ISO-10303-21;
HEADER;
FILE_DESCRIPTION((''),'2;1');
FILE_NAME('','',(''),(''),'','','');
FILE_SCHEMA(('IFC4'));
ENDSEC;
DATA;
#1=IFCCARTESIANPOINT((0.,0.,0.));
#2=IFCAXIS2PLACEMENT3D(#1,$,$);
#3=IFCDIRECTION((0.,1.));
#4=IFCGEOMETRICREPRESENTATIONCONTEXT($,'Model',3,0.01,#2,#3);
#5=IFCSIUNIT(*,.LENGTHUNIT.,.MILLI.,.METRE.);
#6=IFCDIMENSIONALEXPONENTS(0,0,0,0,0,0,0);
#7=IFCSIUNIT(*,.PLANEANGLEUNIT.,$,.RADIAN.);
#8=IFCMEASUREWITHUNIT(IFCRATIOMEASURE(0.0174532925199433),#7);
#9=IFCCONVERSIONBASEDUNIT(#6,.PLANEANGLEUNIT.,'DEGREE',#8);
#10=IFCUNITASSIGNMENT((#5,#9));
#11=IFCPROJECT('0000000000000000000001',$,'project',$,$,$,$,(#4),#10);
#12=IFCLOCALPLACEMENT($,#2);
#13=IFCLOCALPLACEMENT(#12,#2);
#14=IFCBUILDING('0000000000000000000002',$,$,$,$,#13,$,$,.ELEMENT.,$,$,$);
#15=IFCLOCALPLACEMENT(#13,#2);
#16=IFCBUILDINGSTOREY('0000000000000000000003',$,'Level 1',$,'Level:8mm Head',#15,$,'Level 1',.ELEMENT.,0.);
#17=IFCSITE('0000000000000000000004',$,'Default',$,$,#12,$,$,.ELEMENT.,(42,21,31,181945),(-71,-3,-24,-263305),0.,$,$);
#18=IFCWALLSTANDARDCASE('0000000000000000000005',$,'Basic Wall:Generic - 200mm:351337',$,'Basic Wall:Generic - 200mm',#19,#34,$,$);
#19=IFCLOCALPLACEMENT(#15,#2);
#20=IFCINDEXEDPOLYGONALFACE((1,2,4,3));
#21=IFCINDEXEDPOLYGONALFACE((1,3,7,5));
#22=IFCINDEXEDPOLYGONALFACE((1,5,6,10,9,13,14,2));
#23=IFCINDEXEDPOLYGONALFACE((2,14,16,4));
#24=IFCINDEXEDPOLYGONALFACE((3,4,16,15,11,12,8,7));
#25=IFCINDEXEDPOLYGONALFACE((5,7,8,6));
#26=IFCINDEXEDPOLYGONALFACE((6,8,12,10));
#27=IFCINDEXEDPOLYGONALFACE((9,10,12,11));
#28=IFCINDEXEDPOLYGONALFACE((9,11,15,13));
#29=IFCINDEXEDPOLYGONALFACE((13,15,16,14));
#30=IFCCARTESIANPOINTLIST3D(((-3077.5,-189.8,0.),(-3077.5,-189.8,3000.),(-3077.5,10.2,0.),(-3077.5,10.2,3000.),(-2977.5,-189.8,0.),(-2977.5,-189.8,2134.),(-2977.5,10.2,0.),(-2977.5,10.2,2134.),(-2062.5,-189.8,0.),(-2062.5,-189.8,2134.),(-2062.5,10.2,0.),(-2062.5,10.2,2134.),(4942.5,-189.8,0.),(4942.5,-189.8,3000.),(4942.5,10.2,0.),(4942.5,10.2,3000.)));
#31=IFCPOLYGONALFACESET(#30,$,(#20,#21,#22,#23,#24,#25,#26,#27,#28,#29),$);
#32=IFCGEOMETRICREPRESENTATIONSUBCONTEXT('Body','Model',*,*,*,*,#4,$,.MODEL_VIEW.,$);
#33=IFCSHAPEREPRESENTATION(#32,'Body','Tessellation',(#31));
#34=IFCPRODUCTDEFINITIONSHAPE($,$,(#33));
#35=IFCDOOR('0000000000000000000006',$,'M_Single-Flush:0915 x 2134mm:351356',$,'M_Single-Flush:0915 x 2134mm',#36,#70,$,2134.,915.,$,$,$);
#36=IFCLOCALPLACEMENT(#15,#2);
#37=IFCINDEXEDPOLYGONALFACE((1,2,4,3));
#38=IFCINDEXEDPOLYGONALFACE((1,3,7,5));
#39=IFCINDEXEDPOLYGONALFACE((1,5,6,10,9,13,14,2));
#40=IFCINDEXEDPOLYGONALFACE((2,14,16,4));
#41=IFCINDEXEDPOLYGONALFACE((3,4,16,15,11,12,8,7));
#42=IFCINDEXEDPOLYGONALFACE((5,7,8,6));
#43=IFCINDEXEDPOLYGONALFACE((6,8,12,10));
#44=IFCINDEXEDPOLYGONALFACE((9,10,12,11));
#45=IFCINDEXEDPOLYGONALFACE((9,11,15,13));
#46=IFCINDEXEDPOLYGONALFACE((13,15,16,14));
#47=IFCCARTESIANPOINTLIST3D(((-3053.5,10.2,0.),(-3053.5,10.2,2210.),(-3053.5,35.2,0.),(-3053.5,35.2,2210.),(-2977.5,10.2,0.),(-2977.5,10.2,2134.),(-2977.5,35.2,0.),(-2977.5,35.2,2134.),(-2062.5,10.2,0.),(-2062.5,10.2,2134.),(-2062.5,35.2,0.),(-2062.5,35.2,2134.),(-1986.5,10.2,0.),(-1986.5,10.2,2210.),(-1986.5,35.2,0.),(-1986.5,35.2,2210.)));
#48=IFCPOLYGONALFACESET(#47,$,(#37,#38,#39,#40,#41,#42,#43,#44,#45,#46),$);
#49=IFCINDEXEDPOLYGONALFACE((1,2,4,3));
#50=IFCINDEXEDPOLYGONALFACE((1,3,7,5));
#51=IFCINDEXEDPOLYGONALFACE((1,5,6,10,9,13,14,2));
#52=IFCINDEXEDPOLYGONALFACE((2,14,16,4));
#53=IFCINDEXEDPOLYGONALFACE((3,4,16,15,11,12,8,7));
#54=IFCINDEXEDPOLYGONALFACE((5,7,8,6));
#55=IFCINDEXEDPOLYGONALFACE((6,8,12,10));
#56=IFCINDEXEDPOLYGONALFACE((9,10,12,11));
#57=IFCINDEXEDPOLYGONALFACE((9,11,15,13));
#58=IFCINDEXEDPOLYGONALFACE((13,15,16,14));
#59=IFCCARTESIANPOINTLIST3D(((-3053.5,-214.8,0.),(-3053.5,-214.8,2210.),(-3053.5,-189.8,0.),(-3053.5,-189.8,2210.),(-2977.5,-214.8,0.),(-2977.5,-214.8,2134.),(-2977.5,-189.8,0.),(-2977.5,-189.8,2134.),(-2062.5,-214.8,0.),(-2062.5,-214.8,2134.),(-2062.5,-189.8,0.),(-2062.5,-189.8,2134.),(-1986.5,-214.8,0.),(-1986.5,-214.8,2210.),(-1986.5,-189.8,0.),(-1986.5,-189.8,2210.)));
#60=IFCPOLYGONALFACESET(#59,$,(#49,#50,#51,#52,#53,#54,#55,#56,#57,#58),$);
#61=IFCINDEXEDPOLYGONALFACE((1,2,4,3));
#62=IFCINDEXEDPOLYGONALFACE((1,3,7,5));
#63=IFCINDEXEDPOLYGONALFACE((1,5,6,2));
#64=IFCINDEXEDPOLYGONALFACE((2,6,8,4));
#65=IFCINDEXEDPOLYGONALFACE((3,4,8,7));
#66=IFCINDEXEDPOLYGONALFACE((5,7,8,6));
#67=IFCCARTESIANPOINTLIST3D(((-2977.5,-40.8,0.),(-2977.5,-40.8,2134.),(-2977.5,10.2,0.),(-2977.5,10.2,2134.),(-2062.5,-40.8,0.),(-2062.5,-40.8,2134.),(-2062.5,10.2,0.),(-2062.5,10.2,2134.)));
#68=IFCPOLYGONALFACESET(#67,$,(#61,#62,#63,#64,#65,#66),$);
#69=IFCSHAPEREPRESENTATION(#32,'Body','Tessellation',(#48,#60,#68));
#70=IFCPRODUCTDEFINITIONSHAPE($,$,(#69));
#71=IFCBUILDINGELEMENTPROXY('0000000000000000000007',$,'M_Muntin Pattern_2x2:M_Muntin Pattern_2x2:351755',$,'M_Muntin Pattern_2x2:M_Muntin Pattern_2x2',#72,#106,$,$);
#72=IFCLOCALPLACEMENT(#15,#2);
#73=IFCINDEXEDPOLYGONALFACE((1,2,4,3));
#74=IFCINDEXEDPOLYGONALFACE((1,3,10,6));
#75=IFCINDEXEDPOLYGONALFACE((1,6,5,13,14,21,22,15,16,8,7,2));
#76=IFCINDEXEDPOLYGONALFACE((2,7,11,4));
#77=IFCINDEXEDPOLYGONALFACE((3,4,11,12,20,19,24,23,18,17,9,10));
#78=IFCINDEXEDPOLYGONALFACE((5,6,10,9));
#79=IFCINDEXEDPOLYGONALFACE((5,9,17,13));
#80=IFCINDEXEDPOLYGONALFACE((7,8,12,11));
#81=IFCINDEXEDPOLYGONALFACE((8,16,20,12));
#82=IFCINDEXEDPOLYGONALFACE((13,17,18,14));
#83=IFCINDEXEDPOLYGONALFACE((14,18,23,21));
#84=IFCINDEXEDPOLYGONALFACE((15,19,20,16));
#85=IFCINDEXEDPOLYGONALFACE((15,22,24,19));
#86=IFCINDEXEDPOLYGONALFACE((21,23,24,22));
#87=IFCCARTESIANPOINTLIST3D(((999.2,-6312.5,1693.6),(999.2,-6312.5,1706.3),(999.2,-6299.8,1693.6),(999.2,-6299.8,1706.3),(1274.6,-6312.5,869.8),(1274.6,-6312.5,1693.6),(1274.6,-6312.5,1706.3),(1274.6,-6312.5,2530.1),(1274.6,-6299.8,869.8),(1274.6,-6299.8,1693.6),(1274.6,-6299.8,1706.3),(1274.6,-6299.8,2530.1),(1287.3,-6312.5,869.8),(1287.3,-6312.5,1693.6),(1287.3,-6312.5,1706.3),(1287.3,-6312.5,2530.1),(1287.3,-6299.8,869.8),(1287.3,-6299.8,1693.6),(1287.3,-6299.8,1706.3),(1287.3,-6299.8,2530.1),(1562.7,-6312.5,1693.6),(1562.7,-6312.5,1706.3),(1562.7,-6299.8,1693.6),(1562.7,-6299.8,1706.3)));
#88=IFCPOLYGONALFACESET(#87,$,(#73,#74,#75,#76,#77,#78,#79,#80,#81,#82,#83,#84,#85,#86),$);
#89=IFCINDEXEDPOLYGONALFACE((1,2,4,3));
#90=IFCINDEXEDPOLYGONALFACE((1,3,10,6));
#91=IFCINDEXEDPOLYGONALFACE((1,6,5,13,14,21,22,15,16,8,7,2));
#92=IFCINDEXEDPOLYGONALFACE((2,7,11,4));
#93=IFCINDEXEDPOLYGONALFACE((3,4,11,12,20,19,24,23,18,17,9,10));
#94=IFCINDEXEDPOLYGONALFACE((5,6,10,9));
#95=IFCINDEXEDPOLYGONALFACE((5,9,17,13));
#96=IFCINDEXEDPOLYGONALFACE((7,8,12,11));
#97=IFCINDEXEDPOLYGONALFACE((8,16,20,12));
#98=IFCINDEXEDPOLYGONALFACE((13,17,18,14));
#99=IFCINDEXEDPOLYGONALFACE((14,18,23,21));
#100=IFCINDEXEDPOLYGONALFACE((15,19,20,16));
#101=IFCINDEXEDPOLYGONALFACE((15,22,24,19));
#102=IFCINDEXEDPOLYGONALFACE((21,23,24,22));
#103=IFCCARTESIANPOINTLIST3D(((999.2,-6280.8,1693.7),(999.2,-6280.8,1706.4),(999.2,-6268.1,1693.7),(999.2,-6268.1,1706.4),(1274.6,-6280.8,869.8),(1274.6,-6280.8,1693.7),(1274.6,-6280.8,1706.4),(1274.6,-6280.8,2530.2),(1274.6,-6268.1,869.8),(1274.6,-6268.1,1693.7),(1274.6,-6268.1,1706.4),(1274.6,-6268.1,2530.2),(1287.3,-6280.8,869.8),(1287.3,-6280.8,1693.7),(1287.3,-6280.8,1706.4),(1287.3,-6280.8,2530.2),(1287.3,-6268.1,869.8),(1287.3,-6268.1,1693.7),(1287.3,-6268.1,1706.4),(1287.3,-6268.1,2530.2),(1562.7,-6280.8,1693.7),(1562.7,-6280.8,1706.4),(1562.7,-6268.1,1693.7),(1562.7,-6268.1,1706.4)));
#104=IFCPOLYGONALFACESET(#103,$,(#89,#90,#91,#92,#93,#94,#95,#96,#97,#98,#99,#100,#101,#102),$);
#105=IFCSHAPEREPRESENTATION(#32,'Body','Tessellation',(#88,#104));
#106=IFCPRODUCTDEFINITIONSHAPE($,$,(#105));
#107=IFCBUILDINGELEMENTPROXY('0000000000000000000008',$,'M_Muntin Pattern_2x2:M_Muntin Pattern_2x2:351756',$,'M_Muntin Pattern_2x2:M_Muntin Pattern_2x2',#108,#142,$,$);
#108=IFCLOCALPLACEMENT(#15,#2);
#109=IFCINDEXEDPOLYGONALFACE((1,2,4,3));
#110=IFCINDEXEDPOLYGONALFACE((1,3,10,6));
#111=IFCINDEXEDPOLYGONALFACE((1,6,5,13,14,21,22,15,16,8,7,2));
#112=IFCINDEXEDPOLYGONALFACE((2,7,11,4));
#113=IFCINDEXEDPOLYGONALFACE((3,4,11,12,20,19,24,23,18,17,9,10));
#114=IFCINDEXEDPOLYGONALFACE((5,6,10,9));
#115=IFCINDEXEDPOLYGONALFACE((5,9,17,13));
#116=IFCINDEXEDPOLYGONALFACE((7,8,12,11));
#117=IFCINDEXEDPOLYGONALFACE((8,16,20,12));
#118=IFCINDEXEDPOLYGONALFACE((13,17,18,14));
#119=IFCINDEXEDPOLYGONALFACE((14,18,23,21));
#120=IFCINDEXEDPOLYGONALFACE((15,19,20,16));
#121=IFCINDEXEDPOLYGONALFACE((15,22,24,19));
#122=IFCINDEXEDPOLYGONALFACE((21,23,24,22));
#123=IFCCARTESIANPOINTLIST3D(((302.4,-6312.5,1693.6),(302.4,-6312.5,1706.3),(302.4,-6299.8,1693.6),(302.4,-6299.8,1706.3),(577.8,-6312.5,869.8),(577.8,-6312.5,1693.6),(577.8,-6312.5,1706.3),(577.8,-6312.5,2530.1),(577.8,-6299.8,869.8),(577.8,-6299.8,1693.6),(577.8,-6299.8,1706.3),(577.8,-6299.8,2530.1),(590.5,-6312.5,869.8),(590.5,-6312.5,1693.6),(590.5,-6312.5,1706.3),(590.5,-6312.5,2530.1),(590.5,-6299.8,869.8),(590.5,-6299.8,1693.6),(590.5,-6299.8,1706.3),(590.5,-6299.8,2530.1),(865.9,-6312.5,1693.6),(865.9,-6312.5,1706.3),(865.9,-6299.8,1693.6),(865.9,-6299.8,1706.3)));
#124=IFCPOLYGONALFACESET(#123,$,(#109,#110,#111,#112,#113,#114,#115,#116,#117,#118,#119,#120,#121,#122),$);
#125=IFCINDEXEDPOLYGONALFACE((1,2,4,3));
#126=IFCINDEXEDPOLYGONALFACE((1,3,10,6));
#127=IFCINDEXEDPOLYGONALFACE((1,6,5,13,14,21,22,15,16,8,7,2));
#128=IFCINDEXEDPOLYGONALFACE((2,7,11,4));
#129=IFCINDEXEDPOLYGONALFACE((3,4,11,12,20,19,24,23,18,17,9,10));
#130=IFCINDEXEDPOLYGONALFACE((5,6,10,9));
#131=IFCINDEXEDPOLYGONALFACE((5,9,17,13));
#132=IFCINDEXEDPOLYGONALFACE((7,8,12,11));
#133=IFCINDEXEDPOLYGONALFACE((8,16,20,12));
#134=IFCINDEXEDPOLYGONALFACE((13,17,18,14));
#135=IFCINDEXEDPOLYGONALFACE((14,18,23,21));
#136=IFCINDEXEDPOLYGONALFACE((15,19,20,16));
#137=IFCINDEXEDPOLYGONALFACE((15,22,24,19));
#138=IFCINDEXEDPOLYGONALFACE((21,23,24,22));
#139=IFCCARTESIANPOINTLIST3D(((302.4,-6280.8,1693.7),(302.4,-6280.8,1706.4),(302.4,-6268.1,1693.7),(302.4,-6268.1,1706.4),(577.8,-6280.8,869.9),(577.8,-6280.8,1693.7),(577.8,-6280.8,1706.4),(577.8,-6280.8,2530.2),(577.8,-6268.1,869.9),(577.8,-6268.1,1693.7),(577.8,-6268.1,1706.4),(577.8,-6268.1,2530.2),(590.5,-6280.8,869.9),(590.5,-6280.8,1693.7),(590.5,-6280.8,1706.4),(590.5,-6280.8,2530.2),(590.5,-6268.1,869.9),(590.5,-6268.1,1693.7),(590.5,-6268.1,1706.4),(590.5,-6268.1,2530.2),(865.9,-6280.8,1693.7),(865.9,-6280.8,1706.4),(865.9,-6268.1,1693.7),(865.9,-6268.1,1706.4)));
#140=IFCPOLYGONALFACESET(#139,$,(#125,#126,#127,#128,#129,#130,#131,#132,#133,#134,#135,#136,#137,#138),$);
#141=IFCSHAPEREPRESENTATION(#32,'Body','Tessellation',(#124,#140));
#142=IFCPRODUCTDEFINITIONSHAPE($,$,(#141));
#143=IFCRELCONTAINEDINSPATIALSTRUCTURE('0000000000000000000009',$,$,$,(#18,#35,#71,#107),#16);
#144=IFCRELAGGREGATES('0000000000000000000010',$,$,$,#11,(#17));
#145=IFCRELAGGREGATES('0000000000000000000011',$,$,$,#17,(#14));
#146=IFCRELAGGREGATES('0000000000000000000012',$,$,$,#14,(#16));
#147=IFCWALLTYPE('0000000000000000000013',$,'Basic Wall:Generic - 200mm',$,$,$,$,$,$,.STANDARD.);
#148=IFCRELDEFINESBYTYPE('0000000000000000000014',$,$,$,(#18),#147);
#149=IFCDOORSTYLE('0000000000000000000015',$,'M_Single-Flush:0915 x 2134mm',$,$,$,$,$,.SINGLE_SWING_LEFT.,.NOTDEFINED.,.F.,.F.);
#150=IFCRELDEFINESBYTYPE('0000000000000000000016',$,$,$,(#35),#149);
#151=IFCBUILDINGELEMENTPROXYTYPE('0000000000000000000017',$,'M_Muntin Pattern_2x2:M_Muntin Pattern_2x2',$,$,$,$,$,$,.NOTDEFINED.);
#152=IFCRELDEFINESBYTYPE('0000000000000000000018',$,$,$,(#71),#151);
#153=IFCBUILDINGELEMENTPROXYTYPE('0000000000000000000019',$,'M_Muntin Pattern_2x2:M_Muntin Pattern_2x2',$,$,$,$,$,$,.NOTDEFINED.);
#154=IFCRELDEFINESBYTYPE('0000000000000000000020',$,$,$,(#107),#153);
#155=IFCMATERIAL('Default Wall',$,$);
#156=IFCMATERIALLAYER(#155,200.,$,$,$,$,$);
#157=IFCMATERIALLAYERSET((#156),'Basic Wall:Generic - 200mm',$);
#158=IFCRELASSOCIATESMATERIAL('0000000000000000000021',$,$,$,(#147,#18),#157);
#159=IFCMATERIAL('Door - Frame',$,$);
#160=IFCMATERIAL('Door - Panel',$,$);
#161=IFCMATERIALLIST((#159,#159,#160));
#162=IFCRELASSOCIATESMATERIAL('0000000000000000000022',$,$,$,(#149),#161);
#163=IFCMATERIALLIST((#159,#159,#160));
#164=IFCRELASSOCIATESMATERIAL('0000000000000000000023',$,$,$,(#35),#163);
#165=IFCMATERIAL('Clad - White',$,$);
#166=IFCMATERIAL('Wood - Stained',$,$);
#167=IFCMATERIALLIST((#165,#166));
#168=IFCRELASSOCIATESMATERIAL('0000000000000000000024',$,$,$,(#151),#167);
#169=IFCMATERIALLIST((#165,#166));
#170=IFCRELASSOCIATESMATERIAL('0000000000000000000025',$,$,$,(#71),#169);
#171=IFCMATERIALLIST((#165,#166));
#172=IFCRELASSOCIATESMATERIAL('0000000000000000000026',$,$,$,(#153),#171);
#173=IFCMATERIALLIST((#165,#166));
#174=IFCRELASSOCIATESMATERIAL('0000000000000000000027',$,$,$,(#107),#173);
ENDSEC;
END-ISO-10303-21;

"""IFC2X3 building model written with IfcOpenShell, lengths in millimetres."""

from ifc_helpers import new_model, entity, si_unit, converted_unit, direction, frame, frame_2d, origin, place, context, subcontext, project, spatial, polyline, rectangle, outline, extrude, source, transform, mapped, material, material_list, layer, layer_set, layer_usage, type_object, type_shapes, element, fill, save


model = new_model("IFC2X3")

# Units and contexts
model_context = context("Model", 3, precision=0.01, world=origin(), true_north=direction((0.0, 1.0)))
body_context = subcontext(model_context, "Body", "Model", "MODEL_VIEW")
ifc_project = project(units=[si_unit("LENGTHUNIT", "METRE", prefix="MILLI"), converted_unit("PLANEANGLEUNIT", "DEGREE", entity("IfcRatioMeasure", 0.0174532925199433), si_unit("PLANEANGLEUNIT", "RADIAN"), dimensions=[0, 0, 0, 0, 0, 0, 0])], contexts=[model_context])

# Site, building, storey
site_placement = place(None, origin())
site = spatial("IfcSite", under=ifc_project, at=site_placement, Name="Default", CompositionType="ELEMENT", RefLatitude=(42, 21, 31, 181945), RefLongitude=(-71, -3, -24, -263305), RefElevation=0.0)
building_placement = place(site_placement, origin())
building = spatial("IfcBuilding", under=site, at=building_placement, CompositionType="ELEMENT")
storey_placement = place(building_placement, origin())
storey = spatial("IfcBuildingStorey", under=building, at=storey_placement, Name="Level 1", ObjectType="Level:8mm Head", LongName="Level 1", CompositionType="ELEMENT", Elevation=0.0)

# Shared definitions
ifc_material_1 = material(Name="Door - Frame")
ifc_material_2 = material(Name="Door - Panel")

# Wall, opening, door
ifc_material_3 = material(Name="Default Wall")
ifc_layer_1 = layer(ifc_material_3, 200.0)
ifc_layer_set_1 = layer_set([ifc_layer_1], Name="Basic Wall:Generic - 200mm")
ifc_layer_usage_1 = layer_usage(ifc_layer_set_1, "AXIS2", "NEGATIVE", 100.0)
wall_type_1 = type_object("IfcWallType", Name="Basic Wall:Generic - 200mm", PredefinedType="STANDARD", material=ifc_layer_set_1)
wall_1_placement = place(storey_placement, frame((-3077.5, -89.8, 0.0)))
wall_1 = element("IfcWallStandardCase", 1, at=wall_1_placement, inside=storey, type_object=wall_type_1, material=ifc_layer_usage_1, Name="Basic Wall:Generic - 200mm:351337", ObjectType="Basic Wall:Generic - 200mm", context=body_context, shape_type="SweptSolid", body=[
    extrude(rectangle(XDim=8020.0, YDim=200.0, at=frame_2d((4010.0, 0.0), x_axis=(-1.0, 0.0))), origin(), (0.0, 0.0, 1.0), 3000.0),
])
opening_1_placement = place(wall_1_placement, frame((100.0, -100.0, 0.0)))
opening_1 = element("IfcOpeningElement", 2, at=opening_1_placement, cuts=wall_1, ObjectType="Opening", context=body_context, shape_type="SweptSolid", body=[
    extrude(rectangle(XDim=915.0, YDim=2134.0, at=frame_2d((1067.0, 457.5), x_axis=(0.0, -1.0))), frame((0.0, 0.0, 0.0), z_axis=(0.0, 1.0, 0.0), x_axis=(0.0, 0.0, 1.0)), (0.0, 0.0, 1.0), 200.0),
])
ifc_material_list_1 = material_list([ifc_material_1, ifc_material_1, ifc_material_2])
ifc_material_list_2 = material_list([ifc_material_1, ifc_material_1, ifc_material_2])
door_style_1 = type_object("IfcDoorStyle", Name="M_Single-Flush:0915 x 2134mm", ConstructionType="NOTDEFINED", OperationType="SINGLE_SWING_LEFT", ParameterTakesPrecedence=False, Sizeable=False, material=ifc_material_list_2)
shared_shape_1 = source(origin(), body_context, "Body", "SweptSolid", [
    extrude(outline(polyline([(-533.5, -1124.0), (533.5, -1124.0), (533.5, 1086.0), (457.5, 1086.0), (457.5, -1048.0), (-457.5, -1048.0), (-457.5, 1086.0), (-533.5, 1086.0), (-533.5, -1124.0)])), frame((457.5, 225.0, 1086.0), z_axis=(0.0, -1.0, 0.0), x_axis=(-1.0, 0.0, 0.0)), (0.0, 0.0, 1.0), 25.0),
    extrude(outline(polyline([(-1124.0, -533.5), (1086.0, -533.5), (1086.0, -457.5), (-1048.0, -457.5), (-1048.0, 457.5), (1086.0, 457.5), (1086.0, 533.5), (-1124.0, 533.5), (-1124.0, -533.5)])), frame((457.5, 0.0, 1086.0), z_axis=(0.0, -1.0, 0.0), x_axis=(0.0, 0.0, -1.0)), (0.0, 0.0, 1.0), 25.0),
    extrude(rectangle(XDim=915.0, YDim=51.0, at=frame_2d((0.0, 0.0), x_axis=(1.0, 0.0))), frame((457.5, 174.5, 0.0)), (0.0, 0.0, 1.0), 2134.0),
])
type_shapes(door_style_1, [shared_shape_1])
door_1_placement = place(opening_1_placement, origin())
door_1 = element("IfcDoor", 3, at=door_1_placement, inside=storey, type_object=door_style_1, material=ifc_material_list_1, Name="M_Single-Flush:0915 x 2134mm:351356", ObjectType="M_Single-Flush:0915 x 2134mm", OverallHeight=2134.0, OverallWidth=915.0, context=body_context, shape_type="MappedRepresentation", body=[
    mapped(shared_shape_1, transform((0.0, 0.0, 0.0), scale=1.0)),
])
fill(opening_1, door_1)

# Building element proxies
ifc_material_4 = material(Name="Clad - White")
ifc_material_5 = material(Name="Wood - Stained")
ifc_material_list_3 = material_list([ifc_material_4, ifc_material_5])
ifc_material_list_4 = material_list([ifc_material_4, ifc_material_5])
building_element_proxy_type_1 = type_object("IfcBuildingElementProxyType", Name="M_Muntin Pattern_2x2:M_Muntin Pattern_2x2", PredefinedType="NOTDEFINED", material=ifc_material_list_4)
shared_shape_2 = source(origin(), body_context, "Body", "SweptSolid", [
    extrude(outline(polyline([(6.4, -6.4), (830.1, -6.4), (830.1, 6.3), (6.4, 6.3), (6.4, 281.7), (-6.3, 281.7), (-6.3, 6.3), (-830.2, 6.3), (-830.2, -6.4), (-6.3, -6.4), (-6.3, -281.7), (6.4, -281.7), (6.4, -6.4)])), frame((0.0, 9.5, 830.1), z_axis=(0.0, 1.0, 0.0), x_axis=(0.0, 0.0, 1.0)), (0.0, 0.0, 1.0), 12.7),
    extrude(outline(polyline([(6.4, -6.4), (830.2, -6.4), (830.2, 6.3), (6.4, 6.3), (6.4, 281.7), (-6.3, 281.7), (-6.3, 6.3), (-830.2, 6.3), (-830.2, -6.4), (-6.3, -6.4), (-6.3, -281.7), (6.4, -281.7), (6.4, -6.4)])), frame((0.0, -22.2, 830.2), z_axis=(0.0, 1.0, 0.0), x_axis=(0.0, 0.0, 1.0)), (0.0, 0.0, 1.0), 12.7),
])
type_shapes(building_element_proxy_type_1, [shared_shape_2])
proxy_1_placement = place(storey_placement, frame((1281.0, -6290.3, 869.8), z_axis=(0.0, 0.0, 1.0), x_axis=(-1.0, 0.0, 0.0)))
element("IfcBuildingElementProxy", 4, at=proxy_1_placement, inside=storey, type_object=building_element_proxy_type_1, material=ifc_material_list_3, Name="M_Muntin Pattern_2x2:M_Muntin Pattern_2x2:351755", ObjectType="M_Muntin Pattern_2x2:M_Muntin Pattern_2x2", context=body_context, shape_type="MappedRepresentation", body=[
    mapped(shared_shape_2, transform((0.0, 0.0, 0.0), scale=1.0)),
])
ifc_material_list_5 = material_list([ifc_material_4, ifc_material_5])
ifc_material_list_6 = material_list([ifc_material_4, ifc_material_5])
building_element_proxy_type_2 = type_object("IfcBuildingElementProxyType", Name="M_Muntin Pattern_2x2:M_Muntin Pattern_2x2", PredefinedType="NOTDEFINED", material=ifc_material_list_6)
shared_shape_3 = source(origin(), body_context, "Body", "SweptSolid", [
    extrude(outline(polyline([(6.4, -6.4), (830.1, -6.4), (830.1, 6.3), (6.4, 6.3), (6.4, 281.7), (-6.3, 281.7), (-6.3, 6.3), (-830.2, 6.3), (-830.2, -6.4), (-6.3, -6.4), (-6.3, -281.7), (6.4, -281.7), (6.4, -6.4)])), frame((0.0, -22.2, 830.1), z_axis=(0.0, 1.0, 0.0), x_axis=(0.0, 0.0, 1.0)), (0.0, 0.0, 1.0), 12.7),
    extrude(outline(polyline([(6.4, -6.4), (830.2, -6.4), (830.2, 6.3), (6.4, 6.3), (6.4, 281.7), (-6.3, 281.7), (-6.3, 6.3), (-830.2, 6.3), (-830.2, -6.4), (-6.3, -6.4), (-6.3, -281.7), (6.4, -281.7), (6.4, -6.4)])), frame((0.0, 9.5, 830.2), z_axis=(0.0, 1.0, 0.0), x_axis=(0.0, 0.0, 1.0)), (0.0, 0.0, 1.0), 12.7),
])
type_shapes(building_element_proxy_type_2, [shared_shape_3])
proxy_2_placement = place(storey_placement, frame((584.1, -6290.3, 869.9)))
element("IfcBuildingElementProxy", 5, at=proxy_2_placement, inside=storey, type_object=building_element_proxy_type_2, material=ifc_material_list_5, Name="M_Muntin Pattern_2x2:M_Muntin Pattern_2x2:351756", ObjectType="M_Muntin Pattern_2x2:M_Muntin Pattern_2x2", context=body_context, shape_type="MappedRepresentation", body=[
    mapped(shared_shape_3, transform((0.0, 0.0, 0.0), scale=1.0)),
])

save(model, "model.ifc")
